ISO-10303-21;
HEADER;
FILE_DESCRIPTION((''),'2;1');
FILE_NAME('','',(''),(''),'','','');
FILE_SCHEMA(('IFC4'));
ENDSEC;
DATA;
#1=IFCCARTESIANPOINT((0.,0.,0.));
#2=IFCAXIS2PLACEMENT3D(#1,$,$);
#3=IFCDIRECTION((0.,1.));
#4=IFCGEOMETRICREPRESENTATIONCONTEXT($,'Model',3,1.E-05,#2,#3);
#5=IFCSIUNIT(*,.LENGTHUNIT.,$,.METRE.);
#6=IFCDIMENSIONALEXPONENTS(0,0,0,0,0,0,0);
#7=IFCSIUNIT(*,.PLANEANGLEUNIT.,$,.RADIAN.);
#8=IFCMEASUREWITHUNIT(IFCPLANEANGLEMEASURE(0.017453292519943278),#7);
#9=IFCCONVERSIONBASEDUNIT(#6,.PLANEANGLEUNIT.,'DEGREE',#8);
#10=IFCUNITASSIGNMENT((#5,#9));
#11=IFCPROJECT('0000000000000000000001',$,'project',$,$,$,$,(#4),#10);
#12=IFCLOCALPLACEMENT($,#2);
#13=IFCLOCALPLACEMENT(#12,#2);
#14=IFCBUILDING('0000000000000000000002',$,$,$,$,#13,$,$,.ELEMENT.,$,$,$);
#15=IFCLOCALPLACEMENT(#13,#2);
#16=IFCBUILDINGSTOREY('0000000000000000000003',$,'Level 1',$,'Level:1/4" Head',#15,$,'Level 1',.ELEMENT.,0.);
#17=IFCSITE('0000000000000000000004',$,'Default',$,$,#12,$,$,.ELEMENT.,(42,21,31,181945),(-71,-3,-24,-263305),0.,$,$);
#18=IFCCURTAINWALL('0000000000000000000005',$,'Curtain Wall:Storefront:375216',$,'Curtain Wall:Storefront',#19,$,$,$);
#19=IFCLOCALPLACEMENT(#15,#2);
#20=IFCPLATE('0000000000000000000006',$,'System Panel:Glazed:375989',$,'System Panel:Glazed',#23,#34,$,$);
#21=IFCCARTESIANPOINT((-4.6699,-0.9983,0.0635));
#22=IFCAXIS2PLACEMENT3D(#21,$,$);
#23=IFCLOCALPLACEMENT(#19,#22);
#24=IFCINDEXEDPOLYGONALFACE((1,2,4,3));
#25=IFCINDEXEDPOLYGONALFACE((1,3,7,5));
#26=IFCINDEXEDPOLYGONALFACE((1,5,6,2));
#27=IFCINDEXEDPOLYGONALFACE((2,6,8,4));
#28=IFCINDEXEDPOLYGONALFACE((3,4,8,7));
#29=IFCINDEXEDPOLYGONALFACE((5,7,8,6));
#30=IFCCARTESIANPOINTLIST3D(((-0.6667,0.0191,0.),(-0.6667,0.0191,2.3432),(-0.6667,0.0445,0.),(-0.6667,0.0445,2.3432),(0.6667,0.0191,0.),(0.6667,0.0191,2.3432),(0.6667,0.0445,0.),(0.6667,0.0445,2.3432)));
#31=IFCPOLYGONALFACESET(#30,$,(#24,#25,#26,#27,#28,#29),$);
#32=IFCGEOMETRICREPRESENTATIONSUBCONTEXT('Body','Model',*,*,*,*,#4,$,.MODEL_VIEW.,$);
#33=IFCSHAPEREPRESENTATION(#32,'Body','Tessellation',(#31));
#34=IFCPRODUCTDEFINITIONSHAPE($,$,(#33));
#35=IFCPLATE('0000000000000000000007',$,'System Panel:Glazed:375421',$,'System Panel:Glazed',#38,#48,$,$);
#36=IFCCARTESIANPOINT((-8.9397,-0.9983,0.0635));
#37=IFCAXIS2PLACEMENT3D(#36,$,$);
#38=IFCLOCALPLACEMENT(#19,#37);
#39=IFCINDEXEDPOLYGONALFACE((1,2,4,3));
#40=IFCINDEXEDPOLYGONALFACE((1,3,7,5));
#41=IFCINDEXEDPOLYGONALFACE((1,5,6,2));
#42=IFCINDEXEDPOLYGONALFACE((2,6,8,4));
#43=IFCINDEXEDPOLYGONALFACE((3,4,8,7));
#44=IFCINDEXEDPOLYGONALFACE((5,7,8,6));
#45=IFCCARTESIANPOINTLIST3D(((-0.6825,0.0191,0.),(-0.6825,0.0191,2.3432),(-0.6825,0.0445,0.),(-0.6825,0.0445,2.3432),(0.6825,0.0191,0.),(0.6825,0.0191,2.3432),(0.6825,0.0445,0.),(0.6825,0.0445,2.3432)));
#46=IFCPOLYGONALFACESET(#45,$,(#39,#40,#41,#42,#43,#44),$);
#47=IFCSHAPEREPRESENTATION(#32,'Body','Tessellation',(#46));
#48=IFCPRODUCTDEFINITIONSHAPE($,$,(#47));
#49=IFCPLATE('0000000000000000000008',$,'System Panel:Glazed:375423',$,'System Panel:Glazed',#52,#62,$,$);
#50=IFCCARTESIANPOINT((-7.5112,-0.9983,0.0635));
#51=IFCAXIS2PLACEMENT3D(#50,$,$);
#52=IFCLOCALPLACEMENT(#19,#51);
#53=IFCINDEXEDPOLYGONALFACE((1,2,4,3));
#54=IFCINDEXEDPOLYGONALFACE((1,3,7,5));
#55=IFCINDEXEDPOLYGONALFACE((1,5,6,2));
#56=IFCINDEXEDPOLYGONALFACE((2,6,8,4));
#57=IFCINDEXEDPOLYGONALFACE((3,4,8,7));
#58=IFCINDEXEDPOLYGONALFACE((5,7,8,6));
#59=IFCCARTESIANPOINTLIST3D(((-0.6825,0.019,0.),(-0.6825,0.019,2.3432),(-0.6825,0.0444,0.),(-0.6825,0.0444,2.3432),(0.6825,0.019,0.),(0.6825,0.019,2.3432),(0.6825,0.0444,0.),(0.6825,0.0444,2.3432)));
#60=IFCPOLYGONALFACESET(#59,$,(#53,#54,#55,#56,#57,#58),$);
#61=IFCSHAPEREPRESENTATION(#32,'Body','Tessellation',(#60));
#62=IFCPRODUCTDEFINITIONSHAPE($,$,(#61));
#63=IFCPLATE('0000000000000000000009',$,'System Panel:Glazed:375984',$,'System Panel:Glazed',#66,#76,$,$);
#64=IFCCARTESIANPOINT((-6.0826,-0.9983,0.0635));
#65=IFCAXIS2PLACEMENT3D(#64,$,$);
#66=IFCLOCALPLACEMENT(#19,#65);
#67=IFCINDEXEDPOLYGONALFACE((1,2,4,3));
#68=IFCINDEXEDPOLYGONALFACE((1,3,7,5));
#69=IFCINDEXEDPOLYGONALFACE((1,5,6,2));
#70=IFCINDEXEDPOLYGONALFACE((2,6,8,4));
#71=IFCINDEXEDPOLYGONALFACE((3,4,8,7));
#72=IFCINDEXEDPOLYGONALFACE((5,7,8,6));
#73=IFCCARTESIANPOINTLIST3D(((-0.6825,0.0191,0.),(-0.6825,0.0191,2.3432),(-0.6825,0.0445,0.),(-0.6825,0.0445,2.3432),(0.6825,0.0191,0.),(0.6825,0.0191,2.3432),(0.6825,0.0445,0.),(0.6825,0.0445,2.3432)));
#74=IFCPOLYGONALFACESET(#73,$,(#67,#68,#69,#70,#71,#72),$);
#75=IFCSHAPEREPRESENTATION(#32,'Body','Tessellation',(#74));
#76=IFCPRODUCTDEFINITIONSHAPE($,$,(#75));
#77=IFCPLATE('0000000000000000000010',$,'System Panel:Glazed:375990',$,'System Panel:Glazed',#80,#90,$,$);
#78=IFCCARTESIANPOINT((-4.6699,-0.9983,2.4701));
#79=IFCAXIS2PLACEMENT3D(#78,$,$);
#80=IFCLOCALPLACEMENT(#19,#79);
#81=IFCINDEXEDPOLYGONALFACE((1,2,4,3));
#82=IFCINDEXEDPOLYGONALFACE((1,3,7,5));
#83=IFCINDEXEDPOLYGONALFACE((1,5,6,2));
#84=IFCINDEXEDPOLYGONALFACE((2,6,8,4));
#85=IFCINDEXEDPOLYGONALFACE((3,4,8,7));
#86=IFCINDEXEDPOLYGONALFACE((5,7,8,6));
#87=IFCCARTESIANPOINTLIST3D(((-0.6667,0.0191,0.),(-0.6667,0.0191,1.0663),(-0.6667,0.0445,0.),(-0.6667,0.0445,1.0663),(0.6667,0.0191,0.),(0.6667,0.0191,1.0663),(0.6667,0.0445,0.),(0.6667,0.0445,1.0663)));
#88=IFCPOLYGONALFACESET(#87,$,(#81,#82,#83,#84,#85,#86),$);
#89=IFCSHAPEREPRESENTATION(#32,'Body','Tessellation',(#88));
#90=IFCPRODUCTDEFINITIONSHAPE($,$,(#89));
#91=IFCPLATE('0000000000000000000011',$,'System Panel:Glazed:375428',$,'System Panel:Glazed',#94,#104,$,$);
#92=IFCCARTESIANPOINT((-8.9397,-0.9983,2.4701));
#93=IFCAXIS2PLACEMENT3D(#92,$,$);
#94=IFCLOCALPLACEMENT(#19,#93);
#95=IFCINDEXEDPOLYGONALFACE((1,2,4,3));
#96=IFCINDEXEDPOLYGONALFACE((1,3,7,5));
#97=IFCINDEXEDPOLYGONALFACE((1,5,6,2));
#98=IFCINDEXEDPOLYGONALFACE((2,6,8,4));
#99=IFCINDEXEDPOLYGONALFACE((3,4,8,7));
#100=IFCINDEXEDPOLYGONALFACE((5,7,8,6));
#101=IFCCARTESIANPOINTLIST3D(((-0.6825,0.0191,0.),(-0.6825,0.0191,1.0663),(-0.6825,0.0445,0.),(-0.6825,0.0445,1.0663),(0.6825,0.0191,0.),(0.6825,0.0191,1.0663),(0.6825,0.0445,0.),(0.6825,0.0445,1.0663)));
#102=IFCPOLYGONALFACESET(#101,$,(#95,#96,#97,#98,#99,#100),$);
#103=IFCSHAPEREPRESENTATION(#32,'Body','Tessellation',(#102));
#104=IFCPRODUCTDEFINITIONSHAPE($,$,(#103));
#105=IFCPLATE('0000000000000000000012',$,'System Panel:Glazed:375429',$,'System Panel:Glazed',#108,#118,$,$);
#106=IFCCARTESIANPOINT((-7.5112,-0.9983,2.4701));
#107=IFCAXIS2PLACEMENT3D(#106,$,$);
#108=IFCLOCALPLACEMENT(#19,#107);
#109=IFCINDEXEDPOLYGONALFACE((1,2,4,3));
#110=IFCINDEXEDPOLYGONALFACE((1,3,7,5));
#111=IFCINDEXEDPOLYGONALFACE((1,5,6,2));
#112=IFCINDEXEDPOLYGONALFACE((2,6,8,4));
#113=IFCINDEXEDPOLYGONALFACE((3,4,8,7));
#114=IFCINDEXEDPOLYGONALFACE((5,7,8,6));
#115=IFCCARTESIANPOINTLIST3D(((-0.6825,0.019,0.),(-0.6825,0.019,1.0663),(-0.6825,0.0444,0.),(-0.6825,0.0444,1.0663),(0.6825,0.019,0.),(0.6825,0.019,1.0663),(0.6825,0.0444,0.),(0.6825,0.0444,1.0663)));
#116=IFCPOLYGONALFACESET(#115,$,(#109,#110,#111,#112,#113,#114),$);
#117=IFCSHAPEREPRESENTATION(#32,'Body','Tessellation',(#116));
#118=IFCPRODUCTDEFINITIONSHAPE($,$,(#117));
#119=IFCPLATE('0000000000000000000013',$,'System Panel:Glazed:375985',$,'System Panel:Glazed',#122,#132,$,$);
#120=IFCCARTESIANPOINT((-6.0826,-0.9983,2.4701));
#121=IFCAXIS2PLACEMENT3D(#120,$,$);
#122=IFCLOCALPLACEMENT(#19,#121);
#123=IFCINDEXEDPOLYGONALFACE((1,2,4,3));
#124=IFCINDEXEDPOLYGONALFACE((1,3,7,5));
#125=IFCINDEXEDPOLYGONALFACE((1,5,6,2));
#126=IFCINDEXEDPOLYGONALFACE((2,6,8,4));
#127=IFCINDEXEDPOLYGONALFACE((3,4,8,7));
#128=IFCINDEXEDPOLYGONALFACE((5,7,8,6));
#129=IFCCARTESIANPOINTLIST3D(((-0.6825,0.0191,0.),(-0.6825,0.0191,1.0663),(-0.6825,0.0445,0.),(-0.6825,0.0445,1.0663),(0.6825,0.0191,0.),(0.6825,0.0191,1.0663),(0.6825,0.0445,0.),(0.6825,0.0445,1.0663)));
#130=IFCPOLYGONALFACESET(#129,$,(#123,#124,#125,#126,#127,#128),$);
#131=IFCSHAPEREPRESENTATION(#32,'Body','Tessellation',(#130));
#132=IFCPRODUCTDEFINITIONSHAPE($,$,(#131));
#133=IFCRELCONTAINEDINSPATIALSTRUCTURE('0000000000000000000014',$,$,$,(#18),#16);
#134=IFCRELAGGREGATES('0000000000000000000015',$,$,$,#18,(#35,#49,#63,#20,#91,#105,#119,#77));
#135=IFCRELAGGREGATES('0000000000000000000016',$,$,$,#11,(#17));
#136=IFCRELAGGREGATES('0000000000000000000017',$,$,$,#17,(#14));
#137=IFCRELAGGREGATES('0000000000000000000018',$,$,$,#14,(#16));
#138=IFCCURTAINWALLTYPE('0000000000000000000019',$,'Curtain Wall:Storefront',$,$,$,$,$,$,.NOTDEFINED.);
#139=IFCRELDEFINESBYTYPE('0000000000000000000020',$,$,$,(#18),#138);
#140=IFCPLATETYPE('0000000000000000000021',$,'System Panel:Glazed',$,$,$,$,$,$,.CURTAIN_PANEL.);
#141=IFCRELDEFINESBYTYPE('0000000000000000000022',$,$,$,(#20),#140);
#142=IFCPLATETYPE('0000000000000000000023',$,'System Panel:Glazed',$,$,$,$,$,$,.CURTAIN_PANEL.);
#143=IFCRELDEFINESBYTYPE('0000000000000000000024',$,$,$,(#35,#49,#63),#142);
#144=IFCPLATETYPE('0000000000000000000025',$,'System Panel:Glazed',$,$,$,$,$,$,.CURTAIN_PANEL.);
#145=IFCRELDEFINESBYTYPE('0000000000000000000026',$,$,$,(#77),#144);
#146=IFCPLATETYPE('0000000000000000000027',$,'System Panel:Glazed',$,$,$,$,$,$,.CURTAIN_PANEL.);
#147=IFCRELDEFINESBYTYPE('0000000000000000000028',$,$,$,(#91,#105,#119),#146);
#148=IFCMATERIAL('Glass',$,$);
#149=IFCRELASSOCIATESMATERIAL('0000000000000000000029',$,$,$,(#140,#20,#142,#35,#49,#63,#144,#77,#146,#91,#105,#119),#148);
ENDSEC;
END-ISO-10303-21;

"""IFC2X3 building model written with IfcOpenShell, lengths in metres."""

from ifc_helpers import new_model, entity, si_unit, converted_unit, direction, frame, frame_2d, origin, place, context, subcontext, project, spatial, rectangle, extrude, source, transform, mapped, material, type_object, type_shapes, element, aggregate, save


model = new_model("IFC2X3")

# Units and contexts
model_context = context("Model", 3, precision=1e-05, world=origin(), true_north=direction((0.0, 1.0)))
body_context = subcontext(model_context, "Body", "Model", "MODEL_VIEW")
ifc_project = project(units=[si_unit("LENGTHUNIT", "METRE"), converted_unit("PLANEANGLEUNIT", "DEGREE", entity("IfcPlaneAngleMeasure", 0.017453292519943278), si_unit("PLANEANGLEUNIT", "RADIAN"), dimensions=[0, 0, 0, 0, 0, 0, 0])], contexts=[model_context])

# Site, building, storey
site_placement = place(None, origin())
site = spatial("IfcSite", under=ifc_project, at=site_placement, Name="Default", CompositionType="ELEMENT", RefLatitude=(42, 21, 31, 181945), RefLongitude=(-71, -3, -24, -263305), RefElevation=0.0)
building_placement = place(site_placement, origin())
building = spatial("IfcBuilding", under=site, at=building_placement, CompositionType="ELEMENT")
storey_placement = place(building_placement, origin())
storey = spatial("IfcBuildingStorey", under=building, at=storey_placement, Name="Level 1", ObjectType="Level:1/4\" Head", LongName="Level 1", CompositionType="ELEMENT", Elevation=0.0)

# Curtain wall, plates
curtain_wall_type = type_object("IfcCurtainWallType", Name="Curtain Wall:Storefront", PredefinedType="NOTDEFINED")
curtain_wall_placement = place(storey_placement, origin())
curtain_wall = element("IfcCurtainWall", 1, at=curtain_wall_placement, inside=storey, type_object=curtain_wall_type, Name="Curtain Wall:Storefront:375216", ObjectType="Curtain Wall:Storefront")
ifc_material_1 = material(Name="Glass")
plate_type_1 = type_object("IfcPlateType", Name="System Panel:Glazed", PredefinedType="CURTAIN_PANEL", material=ifc_material_1)
shared_shape_1 = source(origin(), body_context, "Body", "SweptSolid", [
    extrude(rectangle(XDim=0.0254, YDim=1.3333, at=frame_2d((0.0, 0.0), x_axis=(1.0, 0.0))), frame((0.0, 0.0318, 0.0), z_axis=(0.0, 0.0, 1.0), x_axis=(0.0, 1.0, 0.0)), (0.0, 0.0, 1.0), 2.3432),
])
type_shapes(plate_type_1, [shared_shape_1])
plate_1_placement = place(curtain_wall_placement, frame((-4.6699, -0.9983, 0.0635)))
plate_1 = element("IfcPlate", 2, at=plate_1_placement, type_object=plate_type_1, material=ifc_material_1, Name="System Panel:Glazed:375989", ObjectType="System Panel:Glazed", context=body_context, shape_type="MappedRepresentation", body=[
    mapped(shared_shape_1, transform((0.0, 0.0, 0.0), scale=1.0)),
])
plate_type_2 = type_object("IfcPlateType", Name="System Panel:Glazed", PredefinedType="CURTAIN_PANEL", material=ifc_material_1)
shared_shape_2 = source(origin(), body_context, "Body", "SweptSolid", [
    extrude(rectangle(XDim=0.0254, YDim=1.3651, at=frame_2d((0.0, 0.0), x_axis=(1.0, 0.0))), frame((0.0, 0.0318, 0.0), z_axis=(0.0, 0.0, 1.0), x_axis=(0.0, 1.0, 0.0)), (0.0, 0.0, 1.0), 2.3432),
])
type_shapes(plate_type_2, [shared_shape_2])
plate_2_placement = place(curtain_wall_placement, frame((-8.9397, -0.9983, 0.0635)))
plate_2 = element("IfcPlate", 3, at=plate_2_placement, type_object=plate_type_2, material=ifc_material_1, Name="System Panel:Glazed:375421", ObjectType="System Panel:Glazed", context=body_context, shape_type="MappedRepresentation", body=[
    mapped(shared_shape_2, transform((0.0, 0.0, 0.0), scale=1.0)),
])
plate_3_placement = place(curtain_wall_placement, frame((-7.5112, -0.9983, 0.0635)))
plate_3 = element("IfcPlate", 4, at=plate_3_placement, type_object=plate_type_2, material=ifc_material_1, Name="System Panel:Glazed:375423", ObjectType="System Panel:Glazed", context=body_context, shape_type="MappedRepresentation", body=[
    mapped(shared_shape_2, transform((0.0, 0.0, 0.0), scale=1.0)),
])
plate_4_placement = place(curtain_wall_placement, frame((-6.0826, -0.9983, 0.0635)))
plate_4 = element("IfcPlate", 5, at=plate_4_placement, type_object=plate_type_2, material=ifc_material_1, Name="System Panel:Glazed:375984", ObjectType="System Panel:Glazed", context=body_context, shape_type="MappedRepresentation", body=[
    mapped(shared_shape_2, transform((0.0, 0.0, 0.0), scale=1.0)),
])
plate_type_3 = type_object("IfcPlateType", Name="System Panel:Glazed", PredefinedType="CURTAIN_PANEL", material=ifc_material_1)
shared_shape_3 = source(origin(), body_context, "Body", "SweptSolid", [
    extrude(rectangle(XDim=0.0254, YDim=1.3333, at=frame_2d((0.0, 0.0), x_axis=(1.0, 0.0))), frame((0.0, 0.0318, 0.0), z_axis=(0.0, 0.0, 1.0), x_axis=(0.0, 1.0, 0.0)), (0.0, 0.0, 1.0), 1.0663),
])
type_shapes(plate_type_3, [shared_shape_3])
plate_5_placement = place(curtain_wall_placement, frame((-4.6699, -0.9983, 2.4701)))
plate_5 = element("IfcPlate", 6, at=plate_5_placement, type_object=plate_type_3, material=ifc_material_1, Name="System Panel:Glazed:375990", ObjectType="System Panel:Glazed", context=body_context, shape_type="MappedRepresentation", body=[
    mapped(shared_shape_3, transform((0.0, 0.0, 0.0), scale=1.0)),
])
plate_type_4 = type_object("IfcPlateType", Name="System Panel:Glazed", PredefinedType="CURTAIN_PANEL", material=ifc_material_1)
shared_shape_4 = source(origin(), body_context, "Body", "SweptSolid", [
    extrude(rectangle(XDim=0.0254, YDim=1.3651, at=frame_2d((0.0, 0.0), x_axis=(1.0, 0.0))), frame((0.0, 0.0318, 0.0), z_axis=(0.0, 0.0, 1.0), x_axis=(0.0, 1.0, 0.0)), (0.0, 0.0, 1.0), 1.0663),
])
type_shapes(plate_type_4, [shared_shape_4])
plate_6_placement = place(curtain_wall_placement, frame((-8.9397, -0.9983, 2.4701)))
plate_6 = element("IfcPlate", 7, at=plate_6_placement, type_object=plate_type_4, material=ifc_material_1, Name="System Panel:Glazed:375428", ObjectType="System Panel:Glazed", context=body_context, shape_type="MappedRepresentation", body=[
    mapped(shared_shape_4, transform((0.0, 0.0, 0.0), scale=1.0)),
])
plate_7_placement = place(curtain_wall_placement, frame((-7.5112, -0.9983, 2.4701)))
plate_7 = element("IfcPlate", 8, at=plate_7_placement, type_object=plate_type_4, material=ifc_material_1, Name="System Panel:Glazed:375429", ObjectType="System Panel:Glazed", context=body_context, shape_type="MappedRepresentation", body=[
    mapped(shared_shape_4, transform((0.0, 0.0, 0.0), scale=1.0)),
])
plate_8_placement = place(curtain_wall_placement, frame((-6.0826, -0.9983, 2.4701)))
plate_8 = element("IfcPlate", 9, at=plate_8_placement, type_object=plate_type_4, material=ifc_material_1, Name="System Panel:Glazed:375985", ObjectType="System Panel:Glazed", context=body_context, shape_type="MappedRepresentation", body=[
    mapped(shared_shape_4, transform((0.0, 0.0, 0.0), scale=1.0)),
])
aggregate(curtain_wall, [plate_2, plate_3, plate_4, plate_1, plate_6, plate_7, plate_8, plate_5])

save(model, "model.ifc")
